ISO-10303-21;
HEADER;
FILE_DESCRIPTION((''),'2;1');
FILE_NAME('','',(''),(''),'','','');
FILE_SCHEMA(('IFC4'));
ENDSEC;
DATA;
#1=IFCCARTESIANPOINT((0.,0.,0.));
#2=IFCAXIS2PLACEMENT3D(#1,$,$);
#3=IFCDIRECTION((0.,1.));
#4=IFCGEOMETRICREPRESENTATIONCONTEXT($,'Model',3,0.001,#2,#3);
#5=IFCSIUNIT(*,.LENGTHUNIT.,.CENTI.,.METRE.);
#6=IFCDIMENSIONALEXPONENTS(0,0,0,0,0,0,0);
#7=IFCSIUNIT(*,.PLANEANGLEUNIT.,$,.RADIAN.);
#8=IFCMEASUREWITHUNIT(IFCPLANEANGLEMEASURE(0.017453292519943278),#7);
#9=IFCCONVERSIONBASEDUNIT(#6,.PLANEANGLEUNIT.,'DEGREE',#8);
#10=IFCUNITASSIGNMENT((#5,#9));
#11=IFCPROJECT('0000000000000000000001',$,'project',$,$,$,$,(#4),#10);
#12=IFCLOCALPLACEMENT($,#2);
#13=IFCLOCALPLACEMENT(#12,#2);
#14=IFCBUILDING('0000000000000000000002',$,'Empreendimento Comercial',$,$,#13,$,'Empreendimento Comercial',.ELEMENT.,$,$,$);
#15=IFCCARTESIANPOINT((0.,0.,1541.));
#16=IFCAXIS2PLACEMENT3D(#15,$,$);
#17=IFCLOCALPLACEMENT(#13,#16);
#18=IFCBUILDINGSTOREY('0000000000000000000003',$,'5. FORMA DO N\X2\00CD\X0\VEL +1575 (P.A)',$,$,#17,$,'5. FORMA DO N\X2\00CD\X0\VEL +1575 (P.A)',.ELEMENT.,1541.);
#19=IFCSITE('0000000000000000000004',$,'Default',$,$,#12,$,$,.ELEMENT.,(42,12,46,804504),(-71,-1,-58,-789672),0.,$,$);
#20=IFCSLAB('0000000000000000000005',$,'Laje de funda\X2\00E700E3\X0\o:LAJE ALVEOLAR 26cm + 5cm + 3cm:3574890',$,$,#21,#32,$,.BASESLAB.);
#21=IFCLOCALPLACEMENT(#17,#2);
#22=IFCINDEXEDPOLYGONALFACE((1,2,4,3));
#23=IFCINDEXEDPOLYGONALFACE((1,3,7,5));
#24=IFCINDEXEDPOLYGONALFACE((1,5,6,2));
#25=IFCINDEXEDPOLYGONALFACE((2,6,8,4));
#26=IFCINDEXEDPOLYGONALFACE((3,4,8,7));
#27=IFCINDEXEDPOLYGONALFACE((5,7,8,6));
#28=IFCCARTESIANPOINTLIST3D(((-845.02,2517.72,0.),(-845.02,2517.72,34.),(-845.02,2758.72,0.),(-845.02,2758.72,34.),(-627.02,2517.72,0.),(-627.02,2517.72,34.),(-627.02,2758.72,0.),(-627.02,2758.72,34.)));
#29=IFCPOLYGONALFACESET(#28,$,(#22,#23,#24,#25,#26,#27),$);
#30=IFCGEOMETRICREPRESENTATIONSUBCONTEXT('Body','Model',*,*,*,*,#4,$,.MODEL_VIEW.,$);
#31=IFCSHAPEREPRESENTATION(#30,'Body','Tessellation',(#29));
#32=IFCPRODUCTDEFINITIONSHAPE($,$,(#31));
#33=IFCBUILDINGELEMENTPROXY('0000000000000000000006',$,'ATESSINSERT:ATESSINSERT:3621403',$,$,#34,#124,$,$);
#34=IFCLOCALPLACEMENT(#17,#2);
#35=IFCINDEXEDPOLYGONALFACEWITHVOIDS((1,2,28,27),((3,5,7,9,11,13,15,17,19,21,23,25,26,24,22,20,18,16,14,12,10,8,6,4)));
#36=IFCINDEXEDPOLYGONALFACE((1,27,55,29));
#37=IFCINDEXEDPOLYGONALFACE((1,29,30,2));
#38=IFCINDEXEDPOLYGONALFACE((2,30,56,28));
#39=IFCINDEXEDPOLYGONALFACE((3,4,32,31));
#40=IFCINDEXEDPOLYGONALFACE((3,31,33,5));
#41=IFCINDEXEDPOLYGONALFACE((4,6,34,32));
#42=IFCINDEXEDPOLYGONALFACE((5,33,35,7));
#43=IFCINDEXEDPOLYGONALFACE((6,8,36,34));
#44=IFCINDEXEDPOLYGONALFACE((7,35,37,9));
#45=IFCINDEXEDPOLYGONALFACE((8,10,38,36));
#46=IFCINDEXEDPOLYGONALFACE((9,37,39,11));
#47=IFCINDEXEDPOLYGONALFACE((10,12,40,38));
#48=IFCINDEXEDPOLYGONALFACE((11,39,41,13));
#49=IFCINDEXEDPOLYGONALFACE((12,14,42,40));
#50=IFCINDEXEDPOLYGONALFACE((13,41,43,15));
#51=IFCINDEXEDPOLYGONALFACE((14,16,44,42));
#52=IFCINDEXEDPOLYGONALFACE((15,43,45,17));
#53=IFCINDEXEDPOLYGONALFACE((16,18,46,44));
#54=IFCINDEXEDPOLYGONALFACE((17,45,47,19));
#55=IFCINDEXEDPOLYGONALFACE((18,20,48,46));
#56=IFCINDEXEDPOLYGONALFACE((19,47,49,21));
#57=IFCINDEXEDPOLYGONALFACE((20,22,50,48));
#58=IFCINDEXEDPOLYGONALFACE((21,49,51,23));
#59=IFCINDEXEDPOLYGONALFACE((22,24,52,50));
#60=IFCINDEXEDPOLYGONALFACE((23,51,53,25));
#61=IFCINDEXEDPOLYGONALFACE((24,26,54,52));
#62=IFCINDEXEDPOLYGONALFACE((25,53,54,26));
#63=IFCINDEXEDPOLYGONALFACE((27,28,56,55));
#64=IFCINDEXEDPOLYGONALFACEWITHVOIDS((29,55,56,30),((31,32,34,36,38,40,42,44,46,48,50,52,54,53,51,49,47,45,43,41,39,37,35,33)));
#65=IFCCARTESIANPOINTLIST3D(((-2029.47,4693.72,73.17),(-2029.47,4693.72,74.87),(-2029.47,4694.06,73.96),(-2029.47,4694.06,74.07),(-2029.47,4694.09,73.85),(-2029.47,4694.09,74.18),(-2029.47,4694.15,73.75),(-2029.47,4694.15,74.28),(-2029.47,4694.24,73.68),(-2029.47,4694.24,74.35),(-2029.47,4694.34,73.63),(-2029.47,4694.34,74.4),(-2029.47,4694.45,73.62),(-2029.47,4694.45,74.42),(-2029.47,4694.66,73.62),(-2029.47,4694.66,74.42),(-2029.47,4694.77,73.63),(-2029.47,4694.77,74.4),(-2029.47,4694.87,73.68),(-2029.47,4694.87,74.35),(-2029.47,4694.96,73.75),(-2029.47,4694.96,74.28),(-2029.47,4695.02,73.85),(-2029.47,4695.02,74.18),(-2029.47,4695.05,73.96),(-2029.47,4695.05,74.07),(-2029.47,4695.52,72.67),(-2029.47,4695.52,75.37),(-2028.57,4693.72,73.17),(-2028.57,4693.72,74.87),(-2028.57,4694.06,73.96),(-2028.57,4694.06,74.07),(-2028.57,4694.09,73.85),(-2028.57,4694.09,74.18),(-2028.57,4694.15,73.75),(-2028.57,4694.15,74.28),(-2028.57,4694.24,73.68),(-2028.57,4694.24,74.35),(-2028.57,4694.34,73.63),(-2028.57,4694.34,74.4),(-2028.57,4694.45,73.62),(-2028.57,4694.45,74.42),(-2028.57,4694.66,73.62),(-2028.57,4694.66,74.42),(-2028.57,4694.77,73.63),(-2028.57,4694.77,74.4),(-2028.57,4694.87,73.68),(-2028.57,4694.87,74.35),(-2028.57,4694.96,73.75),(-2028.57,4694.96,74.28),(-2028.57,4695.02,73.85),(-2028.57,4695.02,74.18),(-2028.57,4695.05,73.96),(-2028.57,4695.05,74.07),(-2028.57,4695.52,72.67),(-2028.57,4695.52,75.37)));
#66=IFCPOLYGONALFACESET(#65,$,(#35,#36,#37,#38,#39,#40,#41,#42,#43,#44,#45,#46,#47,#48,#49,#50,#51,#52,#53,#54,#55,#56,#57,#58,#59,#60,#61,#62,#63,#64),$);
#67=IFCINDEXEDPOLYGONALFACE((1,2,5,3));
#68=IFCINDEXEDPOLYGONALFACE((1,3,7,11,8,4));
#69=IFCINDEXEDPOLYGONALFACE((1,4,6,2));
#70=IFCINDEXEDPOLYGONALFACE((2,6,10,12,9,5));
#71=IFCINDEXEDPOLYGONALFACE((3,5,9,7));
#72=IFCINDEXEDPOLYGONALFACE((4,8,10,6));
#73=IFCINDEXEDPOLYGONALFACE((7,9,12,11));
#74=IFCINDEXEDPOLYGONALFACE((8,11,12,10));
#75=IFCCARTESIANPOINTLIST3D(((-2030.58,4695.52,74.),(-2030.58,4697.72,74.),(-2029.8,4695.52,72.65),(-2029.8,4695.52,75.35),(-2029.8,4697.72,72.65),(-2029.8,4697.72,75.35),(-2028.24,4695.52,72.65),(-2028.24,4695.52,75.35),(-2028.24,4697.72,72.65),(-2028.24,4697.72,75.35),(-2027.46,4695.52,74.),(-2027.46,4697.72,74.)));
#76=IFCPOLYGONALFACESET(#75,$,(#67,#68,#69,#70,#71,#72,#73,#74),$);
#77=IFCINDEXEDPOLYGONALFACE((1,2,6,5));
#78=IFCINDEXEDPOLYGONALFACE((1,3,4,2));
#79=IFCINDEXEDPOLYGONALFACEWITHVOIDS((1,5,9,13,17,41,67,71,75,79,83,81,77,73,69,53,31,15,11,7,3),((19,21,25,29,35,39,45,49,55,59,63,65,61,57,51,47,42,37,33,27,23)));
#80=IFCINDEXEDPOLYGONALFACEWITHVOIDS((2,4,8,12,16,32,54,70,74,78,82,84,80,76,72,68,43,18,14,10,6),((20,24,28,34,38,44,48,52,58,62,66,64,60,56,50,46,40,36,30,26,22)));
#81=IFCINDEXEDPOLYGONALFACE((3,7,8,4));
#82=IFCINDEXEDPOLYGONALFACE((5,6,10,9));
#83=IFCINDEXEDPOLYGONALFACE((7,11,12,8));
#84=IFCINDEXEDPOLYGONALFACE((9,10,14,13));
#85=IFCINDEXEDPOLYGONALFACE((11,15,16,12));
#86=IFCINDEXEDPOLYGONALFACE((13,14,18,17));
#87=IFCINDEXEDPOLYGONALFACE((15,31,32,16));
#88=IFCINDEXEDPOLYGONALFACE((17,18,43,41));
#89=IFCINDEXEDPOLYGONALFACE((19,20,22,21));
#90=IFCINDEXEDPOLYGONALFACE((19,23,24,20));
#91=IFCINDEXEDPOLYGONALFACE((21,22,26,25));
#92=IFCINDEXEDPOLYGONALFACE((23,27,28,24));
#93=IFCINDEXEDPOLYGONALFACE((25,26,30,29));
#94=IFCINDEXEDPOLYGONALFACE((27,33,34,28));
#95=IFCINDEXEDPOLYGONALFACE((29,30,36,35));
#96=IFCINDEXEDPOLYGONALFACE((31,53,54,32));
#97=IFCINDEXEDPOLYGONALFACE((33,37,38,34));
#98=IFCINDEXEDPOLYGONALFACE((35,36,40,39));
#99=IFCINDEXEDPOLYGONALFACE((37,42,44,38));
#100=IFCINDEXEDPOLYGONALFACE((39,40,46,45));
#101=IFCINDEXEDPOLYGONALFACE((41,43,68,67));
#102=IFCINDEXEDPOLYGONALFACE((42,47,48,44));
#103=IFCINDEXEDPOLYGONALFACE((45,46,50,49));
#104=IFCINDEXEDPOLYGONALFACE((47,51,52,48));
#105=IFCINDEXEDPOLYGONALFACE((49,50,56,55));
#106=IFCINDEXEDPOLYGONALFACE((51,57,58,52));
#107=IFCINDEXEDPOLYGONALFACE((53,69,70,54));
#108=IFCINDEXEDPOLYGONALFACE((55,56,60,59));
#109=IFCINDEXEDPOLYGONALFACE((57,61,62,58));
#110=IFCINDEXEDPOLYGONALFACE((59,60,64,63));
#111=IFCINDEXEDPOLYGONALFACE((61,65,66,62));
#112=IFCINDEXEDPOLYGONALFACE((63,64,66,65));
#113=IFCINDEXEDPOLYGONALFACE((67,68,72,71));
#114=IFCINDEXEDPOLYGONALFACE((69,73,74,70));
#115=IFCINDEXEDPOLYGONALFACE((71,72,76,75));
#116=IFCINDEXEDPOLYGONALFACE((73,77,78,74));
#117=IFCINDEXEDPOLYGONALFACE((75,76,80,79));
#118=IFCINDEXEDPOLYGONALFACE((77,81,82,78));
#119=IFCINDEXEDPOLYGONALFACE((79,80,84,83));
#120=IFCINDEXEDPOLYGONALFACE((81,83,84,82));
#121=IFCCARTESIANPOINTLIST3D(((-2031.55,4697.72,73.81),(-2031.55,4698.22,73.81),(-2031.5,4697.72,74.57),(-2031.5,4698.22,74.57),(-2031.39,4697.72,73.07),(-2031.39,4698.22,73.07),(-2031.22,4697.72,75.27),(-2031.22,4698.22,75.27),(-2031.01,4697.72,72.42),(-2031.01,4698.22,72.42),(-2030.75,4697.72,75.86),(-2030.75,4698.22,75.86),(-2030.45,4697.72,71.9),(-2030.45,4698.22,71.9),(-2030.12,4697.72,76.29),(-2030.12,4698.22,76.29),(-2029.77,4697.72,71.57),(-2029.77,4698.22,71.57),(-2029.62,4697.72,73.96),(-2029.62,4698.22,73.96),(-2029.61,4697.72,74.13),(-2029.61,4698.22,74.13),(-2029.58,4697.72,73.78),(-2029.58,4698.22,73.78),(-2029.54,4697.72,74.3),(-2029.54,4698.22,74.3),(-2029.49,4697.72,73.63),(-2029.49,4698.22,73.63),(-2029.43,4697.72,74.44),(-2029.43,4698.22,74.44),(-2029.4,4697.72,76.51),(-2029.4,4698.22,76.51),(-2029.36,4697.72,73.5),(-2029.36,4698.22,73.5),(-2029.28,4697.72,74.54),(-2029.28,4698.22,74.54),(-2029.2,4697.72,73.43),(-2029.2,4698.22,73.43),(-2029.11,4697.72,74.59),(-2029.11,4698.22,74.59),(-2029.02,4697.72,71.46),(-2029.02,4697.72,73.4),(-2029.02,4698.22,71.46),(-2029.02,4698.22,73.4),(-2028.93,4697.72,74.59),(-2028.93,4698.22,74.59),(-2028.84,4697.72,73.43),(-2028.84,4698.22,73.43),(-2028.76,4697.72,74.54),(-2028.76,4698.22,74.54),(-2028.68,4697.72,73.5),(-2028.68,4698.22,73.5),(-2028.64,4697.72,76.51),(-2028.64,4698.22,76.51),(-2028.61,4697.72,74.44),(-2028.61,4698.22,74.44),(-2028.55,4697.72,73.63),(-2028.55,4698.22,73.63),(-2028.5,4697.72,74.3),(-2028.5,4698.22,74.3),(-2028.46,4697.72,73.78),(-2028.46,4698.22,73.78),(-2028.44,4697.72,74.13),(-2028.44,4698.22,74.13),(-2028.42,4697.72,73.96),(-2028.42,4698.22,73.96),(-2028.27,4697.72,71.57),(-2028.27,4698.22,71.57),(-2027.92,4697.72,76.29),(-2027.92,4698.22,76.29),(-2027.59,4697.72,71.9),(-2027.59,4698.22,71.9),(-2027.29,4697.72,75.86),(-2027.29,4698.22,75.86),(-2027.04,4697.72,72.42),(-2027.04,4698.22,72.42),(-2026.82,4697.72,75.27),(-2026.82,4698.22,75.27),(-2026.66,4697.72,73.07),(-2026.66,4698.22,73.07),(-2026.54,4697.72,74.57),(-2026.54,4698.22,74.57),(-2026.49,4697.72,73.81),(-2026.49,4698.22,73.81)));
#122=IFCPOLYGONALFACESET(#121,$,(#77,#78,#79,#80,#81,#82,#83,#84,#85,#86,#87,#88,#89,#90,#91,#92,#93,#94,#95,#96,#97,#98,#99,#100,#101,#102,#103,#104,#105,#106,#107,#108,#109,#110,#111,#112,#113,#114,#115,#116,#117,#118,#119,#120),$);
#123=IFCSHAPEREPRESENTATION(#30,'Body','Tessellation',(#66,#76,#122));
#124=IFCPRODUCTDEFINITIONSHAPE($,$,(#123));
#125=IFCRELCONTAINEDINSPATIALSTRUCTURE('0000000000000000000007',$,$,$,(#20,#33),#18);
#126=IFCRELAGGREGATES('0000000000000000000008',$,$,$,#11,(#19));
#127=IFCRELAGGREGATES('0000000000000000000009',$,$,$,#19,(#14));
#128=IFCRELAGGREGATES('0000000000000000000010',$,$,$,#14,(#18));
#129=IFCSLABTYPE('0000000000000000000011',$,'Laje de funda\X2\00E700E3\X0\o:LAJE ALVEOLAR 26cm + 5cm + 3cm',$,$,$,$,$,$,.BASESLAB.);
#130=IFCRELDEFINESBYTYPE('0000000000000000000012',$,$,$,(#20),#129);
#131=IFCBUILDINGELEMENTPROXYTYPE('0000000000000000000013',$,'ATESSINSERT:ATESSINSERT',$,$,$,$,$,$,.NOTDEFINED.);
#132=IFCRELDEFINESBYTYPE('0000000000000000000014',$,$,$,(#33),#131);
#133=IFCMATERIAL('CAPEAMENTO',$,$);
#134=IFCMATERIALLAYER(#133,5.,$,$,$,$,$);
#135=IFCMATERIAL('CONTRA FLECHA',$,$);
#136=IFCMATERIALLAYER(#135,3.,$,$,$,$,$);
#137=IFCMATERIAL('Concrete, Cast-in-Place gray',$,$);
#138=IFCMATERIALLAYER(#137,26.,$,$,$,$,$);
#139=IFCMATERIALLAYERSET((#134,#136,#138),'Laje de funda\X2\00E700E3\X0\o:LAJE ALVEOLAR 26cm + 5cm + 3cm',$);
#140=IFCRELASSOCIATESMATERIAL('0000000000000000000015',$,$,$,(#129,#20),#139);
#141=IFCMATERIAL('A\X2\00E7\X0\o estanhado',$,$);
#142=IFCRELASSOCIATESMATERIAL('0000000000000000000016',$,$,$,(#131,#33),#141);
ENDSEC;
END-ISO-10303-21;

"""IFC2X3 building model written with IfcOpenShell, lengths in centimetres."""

from ifc_helpers import new_model, entity, si_unit, converted_unit, direction, frame, frame_2d, origin, origin_2d_with_axis, place, context, subcontext, project, spatial, polyline, circle_curve, parameter, trimmed, segment, composite_curve, rectangle, hollow_circle, outline, extrude, source, transform, mapped, material, layer, layer_set, layer_usage, type_object, type_shapes, element, save


model = new_model("IFC2X3")

# Units and contexts
model_context = context("Model", 3, precision=0.001, world=origin(), true_north=direction((0.0, 1.0)))
body_context = subcontext(model_context, "Body", "Model", "MODEL_VIEW")
ifc_project = project(units=[si_unit("LENGTHUNIT", "METRE", prefix="CENTI"), converted_unit("PLANEANGLEUNIT", "DEGREE", entity("IfcPlaneAngleMeasure", 0.017453292519943278), si_unit("PLANEANGLEUNIT", "RADIAN"), dimensions=[0, 0, 0, 0, 0, 0, 0])], contexts=[model_context])

# Site, building, storey
site_placement = place(None, origin())
site = spatial("IfcSite", under=ifc_project, at=site_placement, Name="Default", CompositionType="ELEMENT", RefLatitude=(42, 12, 46, 804504), RefLongitude=(-71, -1, -58, -789672), RefElevation=0.0)
building_placement = place(site_placement, origin())
building = spatial("IfcBuilding", under=site, at=building_placement, Name="Empreendimento Comercial", LongName="Empreendimento Comercial", CompositionType="ELEMENT")
storey_placement = place(building_placement, frame((0.0, 0.0, 1541.0)))
storey = spatial("IfcBuildingStorey", under=building, at=storey_placement, Name="5. FORMA DO NÍVEL +1575 (P.A)", LongName="5. FORMA DO NÍVEL +1575 (P.A)", CompositionType="ELEMENT", Elevation=1541.0)

# Slab
ifc_material_1 = material(Name="CAPEAMENTO")
ifc_layer_1 = layer(ifc_material_1, 5.0)
ifc_material_2 = material(Name="CONTRA FLECHA")
ifc_layer_2 = layer(ifc_material_2, 3.0)
ifc_material_3 = material(Name="Concrete, Cast-in-Place gray")
ifc_layer_3 = layer(ifc_material_3, 26.0)
ifc_layer_set = layer_set([ifc_layer_1, ifc_layer_2, ifc_layer_3], Name="Laje de fundação:LAJE ALVEOLAR 26cm + 5cm + 3cm")
slab_type = type_object("IfcSlabType", Name="Laje de fundação:LAJE ALVEOLAR 26cm + 5cm + 3cm", PredefinedType="BASESLAB", material=ifc_layer_set)
ifc_layer_usage_1 = layer_usage(ifc_layer_set, "AXIS3", "POSITIVE", 0.0)
slab_1_placement = place(storey_placement, origin())
element("IfcSlab", 1, at=slab_1_placement, inside=storey, type_object=slab_type, material=ifc_layer_usage_1, Name="Laje de fundação:LAJE ALVEOLAR 26cm + 5cm + 3cm:3574890", PredefinedType="BASESLAB", context=body_context, shape_type="SweptSolid", body=[
    extrude(rectangle(XDim=241.0, YDim=218.0, at=origin_2d_with_axis()), frame((-736.02, 2638.22, 34.0), z_axis=(0.0, 0.0, -1.0), x_axis=(0.0, 1.0, 0.0)), (0.0, 0.0, 1.0), 34.0),
])

# Building element proxy
ifc_material_4 = material(Name="Aço estanhado")
building_element_proxy_type_1 = type_object("IfcBuildingElementProxyType", Name="ATESSINSERT:ATESSINSERT", PredefinedType="NOTDEFINED", material=ifc_material_4)
shared_shape_1 = source(origin(), body_context, "Body", "SweptSolid", [
    extrude(outline(polyline([(-1.35, -0.9), (1.35, -0.9), (0.85, 0.9), (-0.85, 0.9), (-1.35, -0.9)]), holes=[composite_curve([segment(trimmed(circle_curve(frame_2d((0.0, 0.17), x_axis=(1.0, 0.0)), 0.4), [parameter(0.0)], [parameter(180.0)], True, "PARAMETER"), False, "CONTINUOUS"), segment(polyline([(0.4, 0.17), (0.4, -0.03)]), True, "CONTINUOUS"), segment(trimmed(circle_curve(frame_2d((0.0, -0.03), x_axis=(1.0, 0.0)), 0.4), [parameter(180.0)], [parameter(0.0)], True, "PARAMETER"), False, "CONTINUOUS"), segment(polyline([(-0.4, -0.03), (-0.4, 0.17)]), True, "CONTINUOUS")], self_intersect=False)]), frame((-1.4, -0.45, 30.02), z_axis=(0.0, 1.0, 0.0), x_axis=(0.0, 0.0, 1.0)), (0.0, 0.0, 1.0), 0.9),
    extrude(outline(polyline([(-0.78, -1.35), (0.78, -1.35), (1.56, 0.0), (0.78, 1.35), (-0.78, 1.35), (-1.56, 0.0), (-0.78, -1.35)])), frame((-4.5, 0.0, 30.0), z_axis=(1.0, 0.0, 0.0), x_axis=(0.0, 0.5, 0.866025)), (0.0, 0.0, 1.0), 2.2),
    extrude(hollow_circle(Radius=2.54, WallThickness=1.94, at=frame_2d((0.0, 0.0), x_axis=(1.0, 0.0))), frame((-5.0, 0.0, 30.0), z_axis=(1.0, 0.0, 0.0), x_axis=(0.0, 0.0, -1.0)), (0.0, 0.0, 1.0), 0.5),
])
type_shapes(building_element_proxy_type_1, [shared_shape_1])
for number, where, z_axis, x_axis, name in (
    (2, (-2029.02, 4693.22, 44.0), (0.0, 0.0, 1.0), (0.0, -1.0, 0.0), "ATESSINSERT:ATESSINSERT:3621403"),
):
    element("IfcBuildingElementProxy", number, at=place(storey_placement, frame(where, z_axis=z_axis, x_axis=x_axis)), inside=storey, type_object=building_element_proxy_type_1, material=ifc_material_4, Name=name, context=body_context, shape_type="MappedRepresentation", body=[
        mapped(shared_shape_1, transform((0.0, 0.0, 0.0), scale=1.0)),
    ])

save(model, "model.ifc")
